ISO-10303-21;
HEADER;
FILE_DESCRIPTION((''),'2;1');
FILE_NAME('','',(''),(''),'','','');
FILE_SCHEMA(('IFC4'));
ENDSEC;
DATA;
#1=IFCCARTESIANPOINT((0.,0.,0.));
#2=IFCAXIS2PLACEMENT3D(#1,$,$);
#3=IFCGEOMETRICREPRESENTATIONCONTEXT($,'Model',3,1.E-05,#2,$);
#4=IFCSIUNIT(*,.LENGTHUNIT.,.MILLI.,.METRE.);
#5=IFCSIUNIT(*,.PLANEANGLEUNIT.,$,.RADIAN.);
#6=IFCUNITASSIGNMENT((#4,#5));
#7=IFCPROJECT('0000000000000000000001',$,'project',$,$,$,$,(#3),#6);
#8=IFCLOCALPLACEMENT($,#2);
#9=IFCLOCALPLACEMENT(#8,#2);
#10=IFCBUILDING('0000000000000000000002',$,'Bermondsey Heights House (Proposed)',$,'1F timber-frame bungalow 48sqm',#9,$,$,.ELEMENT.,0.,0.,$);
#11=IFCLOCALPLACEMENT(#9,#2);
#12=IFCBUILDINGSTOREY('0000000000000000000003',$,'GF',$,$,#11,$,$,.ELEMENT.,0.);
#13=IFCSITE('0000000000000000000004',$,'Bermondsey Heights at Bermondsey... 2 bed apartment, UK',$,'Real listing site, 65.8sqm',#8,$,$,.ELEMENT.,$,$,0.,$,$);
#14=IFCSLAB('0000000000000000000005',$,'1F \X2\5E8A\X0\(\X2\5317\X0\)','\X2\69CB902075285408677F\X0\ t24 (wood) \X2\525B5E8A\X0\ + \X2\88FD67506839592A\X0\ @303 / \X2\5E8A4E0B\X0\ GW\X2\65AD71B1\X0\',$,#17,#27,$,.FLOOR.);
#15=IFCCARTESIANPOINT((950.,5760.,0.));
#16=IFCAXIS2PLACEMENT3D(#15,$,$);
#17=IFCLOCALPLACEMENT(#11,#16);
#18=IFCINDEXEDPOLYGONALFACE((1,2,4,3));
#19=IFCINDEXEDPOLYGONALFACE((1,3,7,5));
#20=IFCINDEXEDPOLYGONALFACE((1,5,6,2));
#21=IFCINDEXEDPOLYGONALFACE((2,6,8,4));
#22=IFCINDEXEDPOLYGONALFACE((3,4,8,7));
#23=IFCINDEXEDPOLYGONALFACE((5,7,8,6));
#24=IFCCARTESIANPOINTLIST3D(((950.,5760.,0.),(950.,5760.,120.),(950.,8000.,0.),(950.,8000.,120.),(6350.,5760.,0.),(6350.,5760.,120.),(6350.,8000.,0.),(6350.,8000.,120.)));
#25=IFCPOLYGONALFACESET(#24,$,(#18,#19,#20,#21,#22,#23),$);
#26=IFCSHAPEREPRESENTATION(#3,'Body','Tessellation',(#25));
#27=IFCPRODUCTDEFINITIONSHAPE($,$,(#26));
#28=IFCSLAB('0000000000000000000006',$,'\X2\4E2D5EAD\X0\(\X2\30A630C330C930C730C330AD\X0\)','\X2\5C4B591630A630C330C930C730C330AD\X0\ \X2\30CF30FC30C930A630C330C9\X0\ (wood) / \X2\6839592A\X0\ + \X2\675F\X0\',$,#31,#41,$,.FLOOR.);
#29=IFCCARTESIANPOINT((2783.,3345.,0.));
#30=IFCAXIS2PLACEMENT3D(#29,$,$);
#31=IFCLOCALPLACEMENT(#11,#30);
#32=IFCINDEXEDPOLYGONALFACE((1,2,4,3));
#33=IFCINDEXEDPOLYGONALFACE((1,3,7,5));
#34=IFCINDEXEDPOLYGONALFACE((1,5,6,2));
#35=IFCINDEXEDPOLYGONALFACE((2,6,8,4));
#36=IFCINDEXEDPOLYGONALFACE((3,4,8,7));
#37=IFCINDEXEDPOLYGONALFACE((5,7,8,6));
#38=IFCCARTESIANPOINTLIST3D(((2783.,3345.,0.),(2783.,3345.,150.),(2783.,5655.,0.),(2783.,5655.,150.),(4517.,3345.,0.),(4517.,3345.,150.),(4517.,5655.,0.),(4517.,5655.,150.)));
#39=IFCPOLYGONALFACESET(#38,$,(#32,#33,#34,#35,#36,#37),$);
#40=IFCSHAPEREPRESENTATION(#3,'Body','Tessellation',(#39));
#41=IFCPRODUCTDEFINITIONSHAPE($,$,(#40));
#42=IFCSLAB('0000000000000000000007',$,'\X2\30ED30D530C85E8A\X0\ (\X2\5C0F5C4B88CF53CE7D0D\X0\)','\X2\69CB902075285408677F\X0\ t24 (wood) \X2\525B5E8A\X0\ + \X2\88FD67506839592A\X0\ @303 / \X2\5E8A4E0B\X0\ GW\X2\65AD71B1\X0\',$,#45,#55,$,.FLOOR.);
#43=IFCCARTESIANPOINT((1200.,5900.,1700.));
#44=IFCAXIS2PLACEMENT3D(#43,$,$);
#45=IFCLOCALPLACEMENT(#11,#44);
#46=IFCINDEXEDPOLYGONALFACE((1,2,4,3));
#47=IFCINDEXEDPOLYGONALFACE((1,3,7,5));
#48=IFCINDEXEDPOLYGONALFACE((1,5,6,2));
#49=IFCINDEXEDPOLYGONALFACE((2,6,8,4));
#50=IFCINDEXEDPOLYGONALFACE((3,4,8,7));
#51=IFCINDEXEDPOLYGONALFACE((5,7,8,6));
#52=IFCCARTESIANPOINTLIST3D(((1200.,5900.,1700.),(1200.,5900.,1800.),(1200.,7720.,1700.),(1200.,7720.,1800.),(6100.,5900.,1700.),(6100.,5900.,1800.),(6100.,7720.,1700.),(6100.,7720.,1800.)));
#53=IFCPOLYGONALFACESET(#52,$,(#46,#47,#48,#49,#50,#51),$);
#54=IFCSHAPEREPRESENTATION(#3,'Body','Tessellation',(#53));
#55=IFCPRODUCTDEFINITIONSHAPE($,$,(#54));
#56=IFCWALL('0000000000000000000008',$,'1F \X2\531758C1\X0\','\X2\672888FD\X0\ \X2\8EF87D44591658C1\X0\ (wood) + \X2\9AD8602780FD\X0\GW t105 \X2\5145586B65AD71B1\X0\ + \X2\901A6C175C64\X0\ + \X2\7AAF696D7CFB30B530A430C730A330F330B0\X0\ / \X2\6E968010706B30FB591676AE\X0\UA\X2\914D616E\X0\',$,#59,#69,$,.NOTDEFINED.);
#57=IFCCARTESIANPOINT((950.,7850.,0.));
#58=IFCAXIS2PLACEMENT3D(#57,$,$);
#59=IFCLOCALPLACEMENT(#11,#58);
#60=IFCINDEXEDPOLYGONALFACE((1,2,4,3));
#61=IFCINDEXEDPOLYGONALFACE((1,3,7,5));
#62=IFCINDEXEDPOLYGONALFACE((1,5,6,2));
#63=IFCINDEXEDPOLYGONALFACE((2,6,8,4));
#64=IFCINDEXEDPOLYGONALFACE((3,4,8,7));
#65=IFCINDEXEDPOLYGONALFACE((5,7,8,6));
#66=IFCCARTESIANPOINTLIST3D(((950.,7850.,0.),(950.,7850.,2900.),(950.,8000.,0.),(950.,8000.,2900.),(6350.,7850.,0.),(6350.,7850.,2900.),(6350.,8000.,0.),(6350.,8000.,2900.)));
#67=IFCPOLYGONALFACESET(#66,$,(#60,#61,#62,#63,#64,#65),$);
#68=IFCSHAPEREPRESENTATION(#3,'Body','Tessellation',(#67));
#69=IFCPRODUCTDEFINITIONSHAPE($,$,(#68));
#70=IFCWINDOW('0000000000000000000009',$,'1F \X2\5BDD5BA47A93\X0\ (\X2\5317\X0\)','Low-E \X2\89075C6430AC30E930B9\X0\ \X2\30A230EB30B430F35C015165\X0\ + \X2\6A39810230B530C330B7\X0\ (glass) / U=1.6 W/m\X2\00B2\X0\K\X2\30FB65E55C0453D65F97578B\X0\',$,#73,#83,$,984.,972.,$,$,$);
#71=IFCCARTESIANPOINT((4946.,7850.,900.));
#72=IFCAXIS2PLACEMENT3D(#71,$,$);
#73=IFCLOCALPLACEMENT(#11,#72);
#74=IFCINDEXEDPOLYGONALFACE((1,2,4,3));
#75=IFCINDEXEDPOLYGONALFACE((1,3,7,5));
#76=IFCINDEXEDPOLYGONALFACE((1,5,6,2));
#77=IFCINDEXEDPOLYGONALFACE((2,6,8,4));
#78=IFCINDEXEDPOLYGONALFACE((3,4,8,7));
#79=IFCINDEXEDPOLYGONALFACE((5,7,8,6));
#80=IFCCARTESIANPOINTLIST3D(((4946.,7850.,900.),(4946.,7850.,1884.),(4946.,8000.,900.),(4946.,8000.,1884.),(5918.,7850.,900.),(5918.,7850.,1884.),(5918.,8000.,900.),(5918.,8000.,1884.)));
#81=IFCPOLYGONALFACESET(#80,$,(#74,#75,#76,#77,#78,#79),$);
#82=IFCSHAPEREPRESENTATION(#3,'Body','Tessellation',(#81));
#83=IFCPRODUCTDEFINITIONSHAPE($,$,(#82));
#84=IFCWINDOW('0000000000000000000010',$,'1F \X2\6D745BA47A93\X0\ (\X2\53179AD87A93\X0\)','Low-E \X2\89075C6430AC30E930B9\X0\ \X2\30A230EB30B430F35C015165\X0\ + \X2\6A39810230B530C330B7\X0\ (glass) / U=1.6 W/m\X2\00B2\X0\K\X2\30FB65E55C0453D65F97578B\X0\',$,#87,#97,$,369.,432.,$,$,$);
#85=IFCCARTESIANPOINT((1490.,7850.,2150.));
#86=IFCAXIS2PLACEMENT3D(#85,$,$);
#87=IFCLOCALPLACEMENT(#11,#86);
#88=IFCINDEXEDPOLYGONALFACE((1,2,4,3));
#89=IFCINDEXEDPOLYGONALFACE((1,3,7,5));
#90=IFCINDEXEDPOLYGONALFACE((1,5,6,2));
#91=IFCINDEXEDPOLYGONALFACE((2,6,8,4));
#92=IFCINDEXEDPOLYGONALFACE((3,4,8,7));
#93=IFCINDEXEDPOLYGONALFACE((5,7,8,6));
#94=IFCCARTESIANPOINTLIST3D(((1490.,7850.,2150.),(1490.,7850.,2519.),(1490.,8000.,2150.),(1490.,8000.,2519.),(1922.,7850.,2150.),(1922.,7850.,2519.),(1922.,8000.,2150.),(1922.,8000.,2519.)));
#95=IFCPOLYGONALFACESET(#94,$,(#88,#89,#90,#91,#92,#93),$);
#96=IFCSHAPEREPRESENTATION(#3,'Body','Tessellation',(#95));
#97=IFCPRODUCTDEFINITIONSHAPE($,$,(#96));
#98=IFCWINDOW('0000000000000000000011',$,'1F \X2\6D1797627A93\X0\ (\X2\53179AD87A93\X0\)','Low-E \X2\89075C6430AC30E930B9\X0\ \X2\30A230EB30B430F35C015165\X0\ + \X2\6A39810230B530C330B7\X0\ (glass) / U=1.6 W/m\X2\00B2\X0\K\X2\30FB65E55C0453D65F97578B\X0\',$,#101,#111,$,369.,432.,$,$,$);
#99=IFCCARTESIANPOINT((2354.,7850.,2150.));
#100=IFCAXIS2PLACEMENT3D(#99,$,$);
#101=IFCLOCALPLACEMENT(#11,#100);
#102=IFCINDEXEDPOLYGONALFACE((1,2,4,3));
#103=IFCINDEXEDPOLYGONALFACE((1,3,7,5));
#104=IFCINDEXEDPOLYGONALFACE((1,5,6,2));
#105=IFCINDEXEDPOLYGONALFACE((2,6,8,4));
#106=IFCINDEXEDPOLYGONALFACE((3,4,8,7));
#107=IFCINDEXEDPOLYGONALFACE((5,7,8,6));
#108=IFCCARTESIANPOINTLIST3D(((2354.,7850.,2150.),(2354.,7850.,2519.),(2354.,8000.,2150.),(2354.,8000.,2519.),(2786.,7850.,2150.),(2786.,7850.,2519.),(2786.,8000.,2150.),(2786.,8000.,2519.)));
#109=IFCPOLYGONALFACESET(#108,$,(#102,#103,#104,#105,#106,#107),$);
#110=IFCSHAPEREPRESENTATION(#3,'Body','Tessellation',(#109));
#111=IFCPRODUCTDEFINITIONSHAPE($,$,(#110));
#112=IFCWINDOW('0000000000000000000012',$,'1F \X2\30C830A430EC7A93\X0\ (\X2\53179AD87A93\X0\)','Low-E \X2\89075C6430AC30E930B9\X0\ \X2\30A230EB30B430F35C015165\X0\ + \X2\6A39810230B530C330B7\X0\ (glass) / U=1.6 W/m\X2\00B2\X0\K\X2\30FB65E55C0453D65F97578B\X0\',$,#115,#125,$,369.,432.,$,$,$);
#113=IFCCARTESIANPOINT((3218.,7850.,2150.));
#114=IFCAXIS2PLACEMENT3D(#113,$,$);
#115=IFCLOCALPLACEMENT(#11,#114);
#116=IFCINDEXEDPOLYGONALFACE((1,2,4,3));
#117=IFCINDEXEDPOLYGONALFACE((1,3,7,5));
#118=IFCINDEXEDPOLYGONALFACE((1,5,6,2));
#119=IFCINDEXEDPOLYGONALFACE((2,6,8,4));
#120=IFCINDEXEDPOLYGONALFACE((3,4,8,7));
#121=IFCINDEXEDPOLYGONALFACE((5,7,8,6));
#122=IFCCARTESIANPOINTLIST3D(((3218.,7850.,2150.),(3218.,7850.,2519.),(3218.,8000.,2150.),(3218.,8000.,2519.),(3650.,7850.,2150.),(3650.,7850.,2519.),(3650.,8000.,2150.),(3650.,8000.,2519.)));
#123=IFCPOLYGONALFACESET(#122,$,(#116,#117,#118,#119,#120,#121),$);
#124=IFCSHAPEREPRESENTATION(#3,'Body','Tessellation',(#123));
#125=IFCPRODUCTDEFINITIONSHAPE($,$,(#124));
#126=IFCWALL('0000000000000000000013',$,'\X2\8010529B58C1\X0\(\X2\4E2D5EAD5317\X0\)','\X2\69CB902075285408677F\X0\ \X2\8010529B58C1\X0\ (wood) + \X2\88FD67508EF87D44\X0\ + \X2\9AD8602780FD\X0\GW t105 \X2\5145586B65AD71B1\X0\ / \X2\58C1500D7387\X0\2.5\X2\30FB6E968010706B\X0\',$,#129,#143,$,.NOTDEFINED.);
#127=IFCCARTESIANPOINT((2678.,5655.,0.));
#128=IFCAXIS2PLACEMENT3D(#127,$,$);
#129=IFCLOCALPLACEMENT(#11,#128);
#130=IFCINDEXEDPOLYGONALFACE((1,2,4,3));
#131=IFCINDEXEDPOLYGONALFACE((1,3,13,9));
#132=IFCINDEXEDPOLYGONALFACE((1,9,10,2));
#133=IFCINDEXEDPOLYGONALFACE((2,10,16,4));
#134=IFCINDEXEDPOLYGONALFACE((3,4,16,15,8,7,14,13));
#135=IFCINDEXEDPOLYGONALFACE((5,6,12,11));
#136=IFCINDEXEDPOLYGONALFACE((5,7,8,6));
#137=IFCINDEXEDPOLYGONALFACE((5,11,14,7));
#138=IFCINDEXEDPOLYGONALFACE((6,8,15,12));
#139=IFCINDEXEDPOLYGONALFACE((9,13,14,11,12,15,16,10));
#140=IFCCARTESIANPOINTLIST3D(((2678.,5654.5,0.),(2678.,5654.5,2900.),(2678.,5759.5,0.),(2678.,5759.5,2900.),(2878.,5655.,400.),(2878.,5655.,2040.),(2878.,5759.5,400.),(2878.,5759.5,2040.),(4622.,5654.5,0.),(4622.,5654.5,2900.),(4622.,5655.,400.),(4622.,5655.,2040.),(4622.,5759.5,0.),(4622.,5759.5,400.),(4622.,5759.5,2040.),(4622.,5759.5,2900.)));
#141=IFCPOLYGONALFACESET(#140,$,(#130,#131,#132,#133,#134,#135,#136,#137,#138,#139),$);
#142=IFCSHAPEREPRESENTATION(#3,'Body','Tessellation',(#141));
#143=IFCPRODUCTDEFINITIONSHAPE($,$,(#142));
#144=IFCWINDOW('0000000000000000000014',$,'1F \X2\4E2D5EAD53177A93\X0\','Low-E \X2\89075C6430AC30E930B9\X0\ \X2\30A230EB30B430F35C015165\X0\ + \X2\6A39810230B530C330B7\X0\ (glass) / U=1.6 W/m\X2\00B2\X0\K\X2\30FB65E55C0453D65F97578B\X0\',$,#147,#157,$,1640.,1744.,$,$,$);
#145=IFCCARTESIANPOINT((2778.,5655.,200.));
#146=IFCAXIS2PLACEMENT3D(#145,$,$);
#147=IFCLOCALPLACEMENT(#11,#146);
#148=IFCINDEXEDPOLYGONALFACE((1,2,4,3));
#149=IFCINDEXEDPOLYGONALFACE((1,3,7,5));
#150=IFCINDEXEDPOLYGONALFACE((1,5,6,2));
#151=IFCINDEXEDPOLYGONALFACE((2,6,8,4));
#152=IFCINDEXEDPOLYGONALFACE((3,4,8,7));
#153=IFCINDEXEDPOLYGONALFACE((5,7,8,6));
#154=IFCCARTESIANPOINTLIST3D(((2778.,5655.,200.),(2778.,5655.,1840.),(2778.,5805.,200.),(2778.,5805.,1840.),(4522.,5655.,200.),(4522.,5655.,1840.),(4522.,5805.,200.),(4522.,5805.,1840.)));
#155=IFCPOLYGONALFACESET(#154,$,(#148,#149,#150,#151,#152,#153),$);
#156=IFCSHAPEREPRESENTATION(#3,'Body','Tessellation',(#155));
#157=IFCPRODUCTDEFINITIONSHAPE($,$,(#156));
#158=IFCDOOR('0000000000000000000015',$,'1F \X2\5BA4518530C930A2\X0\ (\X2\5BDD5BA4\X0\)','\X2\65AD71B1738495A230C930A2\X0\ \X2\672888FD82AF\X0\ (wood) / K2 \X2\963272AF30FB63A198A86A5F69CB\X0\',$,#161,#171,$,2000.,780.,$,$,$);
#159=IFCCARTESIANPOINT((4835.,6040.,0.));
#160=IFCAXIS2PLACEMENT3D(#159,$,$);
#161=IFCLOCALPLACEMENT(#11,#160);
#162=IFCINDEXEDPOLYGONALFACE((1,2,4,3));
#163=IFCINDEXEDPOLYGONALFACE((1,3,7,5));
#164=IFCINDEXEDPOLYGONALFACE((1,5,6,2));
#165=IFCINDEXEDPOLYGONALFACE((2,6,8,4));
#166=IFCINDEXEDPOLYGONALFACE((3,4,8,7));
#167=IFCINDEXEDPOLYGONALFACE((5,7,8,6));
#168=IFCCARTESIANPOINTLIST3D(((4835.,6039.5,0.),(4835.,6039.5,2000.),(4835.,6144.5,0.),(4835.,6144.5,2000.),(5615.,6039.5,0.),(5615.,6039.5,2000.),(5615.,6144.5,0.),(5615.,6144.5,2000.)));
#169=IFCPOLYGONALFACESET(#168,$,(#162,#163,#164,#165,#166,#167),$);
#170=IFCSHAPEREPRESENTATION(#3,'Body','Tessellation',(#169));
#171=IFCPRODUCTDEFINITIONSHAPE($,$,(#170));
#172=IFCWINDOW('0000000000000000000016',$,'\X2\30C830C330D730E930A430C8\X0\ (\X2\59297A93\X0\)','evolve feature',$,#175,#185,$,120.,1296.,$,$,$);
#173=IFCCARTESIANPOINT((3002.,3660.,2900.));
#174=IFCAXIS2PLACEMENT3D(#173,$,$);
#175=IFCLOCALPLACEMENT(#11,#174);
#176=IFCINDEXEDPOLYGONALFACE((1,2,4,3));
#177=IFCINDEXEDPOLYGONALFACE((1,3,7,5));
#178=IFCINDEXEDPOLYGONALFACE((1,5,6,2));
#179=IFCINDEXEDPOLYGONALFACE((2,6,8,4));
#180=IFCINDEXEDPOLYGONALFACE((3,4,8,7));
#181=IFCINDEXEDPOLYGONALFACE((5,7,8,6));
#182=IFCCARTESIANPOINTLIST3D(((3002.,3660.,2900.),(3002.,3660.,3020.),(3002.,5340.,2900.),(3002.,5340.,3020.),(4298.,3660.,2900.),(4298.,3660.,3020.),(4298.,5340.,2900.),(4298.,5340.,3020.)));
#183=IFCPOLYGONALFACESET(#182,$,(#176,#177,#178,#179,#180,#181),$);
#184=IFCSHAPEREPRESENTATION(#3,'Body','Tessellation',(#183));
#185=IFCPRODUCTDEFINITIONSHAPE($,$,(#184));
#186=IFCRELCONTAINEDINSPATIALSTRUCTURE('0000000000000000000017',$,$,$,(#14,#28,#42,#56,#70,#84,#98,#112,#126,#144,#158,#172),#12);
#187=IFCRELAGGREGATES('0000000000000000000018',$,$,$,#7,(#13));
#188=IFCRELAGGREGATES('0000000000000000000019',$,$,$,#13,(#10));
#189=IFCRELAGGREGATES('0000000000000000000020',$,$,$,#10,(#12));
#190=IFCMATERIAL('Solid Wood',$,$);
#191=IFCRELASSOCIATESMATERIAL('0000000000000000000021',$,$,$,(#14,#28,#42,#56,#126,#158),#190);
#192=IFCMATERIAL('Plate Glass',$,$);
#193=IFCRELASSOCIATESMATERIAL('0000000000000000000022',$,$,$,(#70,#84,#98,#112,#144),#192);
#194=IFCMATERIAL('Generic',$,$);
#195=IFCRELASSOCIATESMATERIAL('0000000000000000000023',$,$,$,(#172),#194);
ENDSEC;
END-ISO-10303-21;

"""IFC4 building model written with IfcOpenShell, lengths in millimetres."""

from ifc_helpers import new_model, si_unit, frame, frame_2d, origin, place, context, project, spatial, rectangle, extrude, material, element, fill, save


model = new_model("IFC4")

# Units and contexts
model_context = context("Model", 3, precision=1e-05, world=origin())
ifc_project = project(units=[si_unit("LENGTHUNIT", "METRE", prefix="MILLI"), si_unit("PLANEANGLEUNIT", "RADIAN")], contexts=[model_context])

# Site, building, storey
site_placement = place(None, origin())
site = spatial("IfcSite", under=ifc_project, at=site_placement, Name="Bermondsey Heights at Bermondsey... 2 bed apartment, UK", ObjectType="Real listing site, 65.8sqm", CompositionType="ELEMENT", RefElevation=0.0)
building_placement = place(site_placement, origin())
building = spatial("IfcBuilding", under=site, at=building_placement, Name="Bermondsey Heights House (Proposed)", ObjectType="1F timber-frame bungalow 48sqm", CompositionType="ELEMENT", ElevationOfRefHeight=0.0, ElevationOfTerrain=0.0)
storey_placement = place(building_placement, origin())
storey = spatial("IfcBuildingStorey", under=building, at=storey_placement, Name="GF", CompositionType="ELEMENT", Elevation=0.0)

# Slabs
ifc_material_1 = material(Name="Solid Wood")
slab_1_placement = place(storey_placement, frame((950.0, 5760.0, 0.0)))
element("IfcSlab", 1, at=slab_1_placement, inside=storey, material=ifc_material_1, Name="1F 床(北)", Description="構造用合板 t24 (wood) 剛床 + 製材根太 @303 / 床下 GW断熱", PredefinedType="FLOOR", context=model_context, shape_type="SweptSolid", body=[
    extrude(rectangle(XDim=5400.0, YDim=2240.0, at=frame_2d((2700.0, 1120.0))), frame((950.0, 5760.0, 0.0)), (0.0, 0.0, 1.0), 120.0),
])
slab_2_placement = place(storey_placement, frame((2783.0, 3345.0, 0.0)))
element("IfcSlab", 2, at=slab_2_placement, inside=storey, material=ifc_material_1, Name="中庭(ウッドデッキ)", Description="屋外ウッドデッキ ハードウッド (wood) / 根太 + 束", PredefinedType="FLOOR", context=model_context, shape_type="SweptSolid", body=[
    extrude(rectangle(XDim=1734.0, YDim=2310.0, at=frame_2d((867.0, 1155.0))), frame((2783.0, 3345.0, 0.0)), (0.0, 0.0, 1.0), 150.0),
])
slab_3_placement = place(storey_placement, frame((1200.0, 5900.0, 1700.0)))
element("IfcSlab", 3, at=slab_3_placement, inside=storey, material=ifc_material_1, Name="ロフト床 (小屋裏収納)", Description="構造用合板 t24 (wood) 剛床 + 製材根太 @303 / 床下 GW断熱", PredefinedType="FLOOR", context=model_context, shape_type="SweptSolid", body=[
    extrude(rectangle(XDim=4900.0, YDim=1820.0, at=frame_2d((2450.0, 910.0))), frame((1200.0, 5900.0, 1700.0)), (0.0, 0.0, 1.0), 100.0),
])

# Wall, openings, windows
wall_1_placement = place(storey_placement, frame((950.0, 7850.0, 0.0)))
wall_1 = element("IfcWall", 4, at=wall_1_placement, inside=storey, material=ifc_material_1, Name="1F 北壁", Description="木製 軸組外壁 (wood) + 高性能GW t105 充填断熱 + 通気層 + 窯業系サイディング / 準耐火・外皮UA配慮", PredefinedType="NOTDEFINED", context=model_context, shape_type="SweptSolid", body=[
    extrude(rectangle(XDim=5400.0, YDim=150.0, at=frame_2d((2700.0, 75.0))), frame((950.0, 7850.0, 0.0)), (0.0, 0.0, 1.0), 2900.0),
])
opening_1_placement = place(storey_placement, frame((4946.0, 7850.0, 900.0)))
opening_1 = element("IfcOpeningElement", 5, at=opening_1_placement, cuts=wall_1, PredefinedType="NOTDEFINED", context=model_context, shape_type="SweptSolid", body=[
    extrude(rectangle(XDim=972.0, YDim=150.0, at=frame_2d((486.0, 75.0))), frame((4946.0, 7850.0, 900.0)), (0.0, 0.0, 1.0), 984.0),
])
opening_2_placement = place(storey_placement, frame((1490.0, 7850.0, 2150.0)))
opening_2 = element("IfcOpeningElement", 6, at=opening_2_placement, cuts=wall_1, PredefinedType="NOTDEFINED", context=model_context, shape_type="SweptSolid", body=[
    extrude(rectangle(XDim=432.0, YDim=150.0, at=frame_2d((216.0, 75.0))), frame((1490.0, 7850.0, 2150.0)), (0.0, 0.0, 1.0), 369.0),
])
opening_3_placement = place(storey_placement, frame((2354.0, 7850.0, 2150.0)))
opening_3 = element("IfcOpeningElement", 7, at=opening_3_placement, cuts=wall_1, PredefinedType="NOTDEFINED", context=model_context, shape_type="SweptSolid", body=[
    extrude(rectangle(XDim=432.0, YDim=150.0, at=frame_2d((216.0, 75.0))), frame((2354.0, 7850.0, 2150.0)), (0.0, 0.0, 1.0), 369.0),
])
opening_4_placement = place(storey_placement, frame((3218.0, 7850.0, 2150.0)))
opening_4 = element("IfcOpeningElement", 8, at=opening_4_placement, cuts=wall_1, PredefinedType="NOTDEFINED", context=model_context, shape_type="SweptSolid", body=[
    extrude(rectangle(XDim=432.0, YDim=150.0, at=frame_2d((216.0, 75.0))), frame((3218.0, 7850.0, 2150.0)), (0.0, 0.0, 1.0), 369.0),
])
ifc_material_2 = material(Name="Plate Glass")
window_1_placement = place(storey_placement, frame((4946.0, 7850.0, 900.0)))
window_1 = element("IfcWindow", 9, at=window_1_placement, inside=storey, material=ifc_material_2, Name="1F 寝室窓 (北)", Description="Low-E 複層ガラス アルゴン封入 + 樹脂サッシ (glass) / U=1.6 W/m²K・日射取得型", OverallHeight=984.0, OverallWidth=972.0, context=model_context, shape_type="SweptSolid", body=[
    extrude(rectangle(XDim=972.0, YDim=150.0, at=frame_2d((486.0, 75.0))), frame((4946.0, 7850.0, 900.0)), (0.0, 0.0, 1.0), 984.0),
])
fill(opening_1, window_1)
window_2_placement = place(storey_placement, frame((1490.0, 7850.0, 2150.0)))
window_2 = element("IfcWindow", 10, at=window_2_placement, inside=storey, material=ifc_material_2, Name="1F 浴室窓 (北高窓)", Description="Low-E 複層ガラス アルゴン封入 + 樹脂サッシ (glass) / U=1.6 W/m²K・日射取得型", OverallHeight=369.0, OverallWidth=432.0, context=model_context, shape_type="SweptSolid", body=[
    extrude(rectangle(XDim=432.0, YDim=150.0, at=frame_2d((216.0, 75.0))), frame((1490.0, 7850.0, 2150.0)), (0.0, 0.0, 1.0), 369.0),
])
fill(opening_2, window_2)
window_3_placement = place(storey_placement, frame((2354.0, 7850.0, 2150.0)))
window_3 = element("IfcWindow", 11, at=window_3_placement, inside=storey, material=ifc_material_2, Name="1F 洗面窓 (北高窓)", Description="Low-E 複層ガラス アルゴン封入 + 樹脂サッシ (glass) / U=1.6 W/m²K・日射取得型", OverallHeight=369.0, OverallWidth=432.0, context=model_context, shape_type="SweptSolid", body=[
    extrude(rectangle(XDim=432.0, YDim=150.0, at=frame_2d((216.0, 75.0))), frame((2354.0, 7850.0, 2150.0)), (0.0, 0.0, 1.0), 369.0),
])
fill(opening_3, window_3)
window_4_placement = place(storey_placement, frame((3218.0, 7850.0, 2150.0)))
window_4 = element("IfcWindow", 12, at=window_4_placement, inside=storey, material=ifc_material_2, Name="1F トイレ窓 (北高窓)", Description="Low-E 複層ガラス アルゴン封入 + 樹脂サッシ (glass) / U=1.6 W/m²K・日射取得型", OverallHeight=369.0, OverallWidth=432.0, context=model_context, shape_type="SweptSolid", body=[
    extrude(rectangle(XDim=432.0, YDim=150.0, at=frame_2d((216.0, 75.0))), frame((3218.0, 7850.0, 2150.0)), (0.0, 0.0, 1.0), 369.0),
])
fill(opening_4, window_4)

# Wall, opening, window
wall_2_placement = place(storey_placement, frame((2678.0, 5655.0, 0.0)))
wall_2 = element("IfcWall", 13, at=wall_2_placement, inside=storey, material=ifc_material_1, Name="耐力壁(中庭北)", Description="構造用合板 耐力壁 (wood) + 製材軸組 + 高性能GW t105 充填断熱 / 壁倍率2.5・準耐火", PredefinedType="NOTDEFINED", context=model_context, shape_type="SweptSolid", body=[
    extrude(rectangle(XDim=1944.0, YDim=105.0, at=frame_2d((972.0, 52.0))), frame((2678.0, 5655.0, 0.0)), (0.0, 0.0, 1.0), 2900.0),
])
opening_5_placement = place(storey_placement, frame((2778.0, 5655.0, 200.0)))
opening_5 = element("IfcOpeningElement", 14, at=opening_5_placement, cuts=wall_2, PredefinedType="NOTDEFINED", context=model_context, shape_type="SweptSolid", body=[
    extrude(rectangle(XDim=1744.0, YDim=150.0, at=frame_2d((872.0, 75.0))), frame((2778.0, 5655.0, 200.0)), (0.0, 0.0, 1.0), 1640.0),
])
window_5_placement = place(storey_placement, frame((2778.0, 5655.0, 200.0)))
window_5 = element("IfcWindow", 15, at=window_5_placement, inside=storey, material=ifc_material_2, Name="1F 中庭北窓", Description="Low-E 複層ガラス アルゴン封入 + 樹脂サッシ (glass) / U=1.6 W/m²K・日射取得型", OverallHeight=1640.0, OverallWidth=1744.0, context=model_context, shape_type="SweptSolid", body=[
    extrude(rectangle(XDim=1744.0, YDim=150.0, at=frame_2d((872.0, 75.0))), frame((2778.0, 5655.0, 200.0)), (0.0, 0.0, 1.0), 1640.0),
])
fill(opening_5, window_5)

# Door
door_1_placement = place(storey_placement, frame((4835.0, 6040.0, 0.0)))
element("IfcDoor", 16, at=door_1_placement, inside=storey, material=ifc_material_1, Name="1F 室内ドア (寝室)", Description="断熱玄関ドア 木製芯 (wood) / K2 防犯・採風機構", OverallHeight=2000.0, OverallWidth=780.0, context=model_context, shape_type="SweptSolid", body=[
    extrude(rectangle(XDim=780.0, YDim=105.0, at=frame_2d((390.0, 52.0))), frame((4835.0, 6040.0, 0.0)), (0.0, 0.0, 1.0), 2000.0),
])

# Window
ifc_material_3 = material(Name="Generic")
window_6_placement = place(storey_placement, frame((3002.0, 3660.0, 2900.0)))
element("IfcWindow", 17, at=window_6_placement, inside=storey, material=ifc_material_3, Name="トップライト (天窓)", Description="evolve feature", OverallHeight=120.0, OverallWidth=1296.0, context=model_context, shape_type="SweptSolid", body=[
    extrude(rectangle(XDim=1296.0, YDim=1680.0, at=frame_2d((648.0, 840.0))), frame((3002.0, 3660.0, 2900.0)), (0.0, 0.0, 1.0), 120.0),
])

save(model, "model.ifc")
